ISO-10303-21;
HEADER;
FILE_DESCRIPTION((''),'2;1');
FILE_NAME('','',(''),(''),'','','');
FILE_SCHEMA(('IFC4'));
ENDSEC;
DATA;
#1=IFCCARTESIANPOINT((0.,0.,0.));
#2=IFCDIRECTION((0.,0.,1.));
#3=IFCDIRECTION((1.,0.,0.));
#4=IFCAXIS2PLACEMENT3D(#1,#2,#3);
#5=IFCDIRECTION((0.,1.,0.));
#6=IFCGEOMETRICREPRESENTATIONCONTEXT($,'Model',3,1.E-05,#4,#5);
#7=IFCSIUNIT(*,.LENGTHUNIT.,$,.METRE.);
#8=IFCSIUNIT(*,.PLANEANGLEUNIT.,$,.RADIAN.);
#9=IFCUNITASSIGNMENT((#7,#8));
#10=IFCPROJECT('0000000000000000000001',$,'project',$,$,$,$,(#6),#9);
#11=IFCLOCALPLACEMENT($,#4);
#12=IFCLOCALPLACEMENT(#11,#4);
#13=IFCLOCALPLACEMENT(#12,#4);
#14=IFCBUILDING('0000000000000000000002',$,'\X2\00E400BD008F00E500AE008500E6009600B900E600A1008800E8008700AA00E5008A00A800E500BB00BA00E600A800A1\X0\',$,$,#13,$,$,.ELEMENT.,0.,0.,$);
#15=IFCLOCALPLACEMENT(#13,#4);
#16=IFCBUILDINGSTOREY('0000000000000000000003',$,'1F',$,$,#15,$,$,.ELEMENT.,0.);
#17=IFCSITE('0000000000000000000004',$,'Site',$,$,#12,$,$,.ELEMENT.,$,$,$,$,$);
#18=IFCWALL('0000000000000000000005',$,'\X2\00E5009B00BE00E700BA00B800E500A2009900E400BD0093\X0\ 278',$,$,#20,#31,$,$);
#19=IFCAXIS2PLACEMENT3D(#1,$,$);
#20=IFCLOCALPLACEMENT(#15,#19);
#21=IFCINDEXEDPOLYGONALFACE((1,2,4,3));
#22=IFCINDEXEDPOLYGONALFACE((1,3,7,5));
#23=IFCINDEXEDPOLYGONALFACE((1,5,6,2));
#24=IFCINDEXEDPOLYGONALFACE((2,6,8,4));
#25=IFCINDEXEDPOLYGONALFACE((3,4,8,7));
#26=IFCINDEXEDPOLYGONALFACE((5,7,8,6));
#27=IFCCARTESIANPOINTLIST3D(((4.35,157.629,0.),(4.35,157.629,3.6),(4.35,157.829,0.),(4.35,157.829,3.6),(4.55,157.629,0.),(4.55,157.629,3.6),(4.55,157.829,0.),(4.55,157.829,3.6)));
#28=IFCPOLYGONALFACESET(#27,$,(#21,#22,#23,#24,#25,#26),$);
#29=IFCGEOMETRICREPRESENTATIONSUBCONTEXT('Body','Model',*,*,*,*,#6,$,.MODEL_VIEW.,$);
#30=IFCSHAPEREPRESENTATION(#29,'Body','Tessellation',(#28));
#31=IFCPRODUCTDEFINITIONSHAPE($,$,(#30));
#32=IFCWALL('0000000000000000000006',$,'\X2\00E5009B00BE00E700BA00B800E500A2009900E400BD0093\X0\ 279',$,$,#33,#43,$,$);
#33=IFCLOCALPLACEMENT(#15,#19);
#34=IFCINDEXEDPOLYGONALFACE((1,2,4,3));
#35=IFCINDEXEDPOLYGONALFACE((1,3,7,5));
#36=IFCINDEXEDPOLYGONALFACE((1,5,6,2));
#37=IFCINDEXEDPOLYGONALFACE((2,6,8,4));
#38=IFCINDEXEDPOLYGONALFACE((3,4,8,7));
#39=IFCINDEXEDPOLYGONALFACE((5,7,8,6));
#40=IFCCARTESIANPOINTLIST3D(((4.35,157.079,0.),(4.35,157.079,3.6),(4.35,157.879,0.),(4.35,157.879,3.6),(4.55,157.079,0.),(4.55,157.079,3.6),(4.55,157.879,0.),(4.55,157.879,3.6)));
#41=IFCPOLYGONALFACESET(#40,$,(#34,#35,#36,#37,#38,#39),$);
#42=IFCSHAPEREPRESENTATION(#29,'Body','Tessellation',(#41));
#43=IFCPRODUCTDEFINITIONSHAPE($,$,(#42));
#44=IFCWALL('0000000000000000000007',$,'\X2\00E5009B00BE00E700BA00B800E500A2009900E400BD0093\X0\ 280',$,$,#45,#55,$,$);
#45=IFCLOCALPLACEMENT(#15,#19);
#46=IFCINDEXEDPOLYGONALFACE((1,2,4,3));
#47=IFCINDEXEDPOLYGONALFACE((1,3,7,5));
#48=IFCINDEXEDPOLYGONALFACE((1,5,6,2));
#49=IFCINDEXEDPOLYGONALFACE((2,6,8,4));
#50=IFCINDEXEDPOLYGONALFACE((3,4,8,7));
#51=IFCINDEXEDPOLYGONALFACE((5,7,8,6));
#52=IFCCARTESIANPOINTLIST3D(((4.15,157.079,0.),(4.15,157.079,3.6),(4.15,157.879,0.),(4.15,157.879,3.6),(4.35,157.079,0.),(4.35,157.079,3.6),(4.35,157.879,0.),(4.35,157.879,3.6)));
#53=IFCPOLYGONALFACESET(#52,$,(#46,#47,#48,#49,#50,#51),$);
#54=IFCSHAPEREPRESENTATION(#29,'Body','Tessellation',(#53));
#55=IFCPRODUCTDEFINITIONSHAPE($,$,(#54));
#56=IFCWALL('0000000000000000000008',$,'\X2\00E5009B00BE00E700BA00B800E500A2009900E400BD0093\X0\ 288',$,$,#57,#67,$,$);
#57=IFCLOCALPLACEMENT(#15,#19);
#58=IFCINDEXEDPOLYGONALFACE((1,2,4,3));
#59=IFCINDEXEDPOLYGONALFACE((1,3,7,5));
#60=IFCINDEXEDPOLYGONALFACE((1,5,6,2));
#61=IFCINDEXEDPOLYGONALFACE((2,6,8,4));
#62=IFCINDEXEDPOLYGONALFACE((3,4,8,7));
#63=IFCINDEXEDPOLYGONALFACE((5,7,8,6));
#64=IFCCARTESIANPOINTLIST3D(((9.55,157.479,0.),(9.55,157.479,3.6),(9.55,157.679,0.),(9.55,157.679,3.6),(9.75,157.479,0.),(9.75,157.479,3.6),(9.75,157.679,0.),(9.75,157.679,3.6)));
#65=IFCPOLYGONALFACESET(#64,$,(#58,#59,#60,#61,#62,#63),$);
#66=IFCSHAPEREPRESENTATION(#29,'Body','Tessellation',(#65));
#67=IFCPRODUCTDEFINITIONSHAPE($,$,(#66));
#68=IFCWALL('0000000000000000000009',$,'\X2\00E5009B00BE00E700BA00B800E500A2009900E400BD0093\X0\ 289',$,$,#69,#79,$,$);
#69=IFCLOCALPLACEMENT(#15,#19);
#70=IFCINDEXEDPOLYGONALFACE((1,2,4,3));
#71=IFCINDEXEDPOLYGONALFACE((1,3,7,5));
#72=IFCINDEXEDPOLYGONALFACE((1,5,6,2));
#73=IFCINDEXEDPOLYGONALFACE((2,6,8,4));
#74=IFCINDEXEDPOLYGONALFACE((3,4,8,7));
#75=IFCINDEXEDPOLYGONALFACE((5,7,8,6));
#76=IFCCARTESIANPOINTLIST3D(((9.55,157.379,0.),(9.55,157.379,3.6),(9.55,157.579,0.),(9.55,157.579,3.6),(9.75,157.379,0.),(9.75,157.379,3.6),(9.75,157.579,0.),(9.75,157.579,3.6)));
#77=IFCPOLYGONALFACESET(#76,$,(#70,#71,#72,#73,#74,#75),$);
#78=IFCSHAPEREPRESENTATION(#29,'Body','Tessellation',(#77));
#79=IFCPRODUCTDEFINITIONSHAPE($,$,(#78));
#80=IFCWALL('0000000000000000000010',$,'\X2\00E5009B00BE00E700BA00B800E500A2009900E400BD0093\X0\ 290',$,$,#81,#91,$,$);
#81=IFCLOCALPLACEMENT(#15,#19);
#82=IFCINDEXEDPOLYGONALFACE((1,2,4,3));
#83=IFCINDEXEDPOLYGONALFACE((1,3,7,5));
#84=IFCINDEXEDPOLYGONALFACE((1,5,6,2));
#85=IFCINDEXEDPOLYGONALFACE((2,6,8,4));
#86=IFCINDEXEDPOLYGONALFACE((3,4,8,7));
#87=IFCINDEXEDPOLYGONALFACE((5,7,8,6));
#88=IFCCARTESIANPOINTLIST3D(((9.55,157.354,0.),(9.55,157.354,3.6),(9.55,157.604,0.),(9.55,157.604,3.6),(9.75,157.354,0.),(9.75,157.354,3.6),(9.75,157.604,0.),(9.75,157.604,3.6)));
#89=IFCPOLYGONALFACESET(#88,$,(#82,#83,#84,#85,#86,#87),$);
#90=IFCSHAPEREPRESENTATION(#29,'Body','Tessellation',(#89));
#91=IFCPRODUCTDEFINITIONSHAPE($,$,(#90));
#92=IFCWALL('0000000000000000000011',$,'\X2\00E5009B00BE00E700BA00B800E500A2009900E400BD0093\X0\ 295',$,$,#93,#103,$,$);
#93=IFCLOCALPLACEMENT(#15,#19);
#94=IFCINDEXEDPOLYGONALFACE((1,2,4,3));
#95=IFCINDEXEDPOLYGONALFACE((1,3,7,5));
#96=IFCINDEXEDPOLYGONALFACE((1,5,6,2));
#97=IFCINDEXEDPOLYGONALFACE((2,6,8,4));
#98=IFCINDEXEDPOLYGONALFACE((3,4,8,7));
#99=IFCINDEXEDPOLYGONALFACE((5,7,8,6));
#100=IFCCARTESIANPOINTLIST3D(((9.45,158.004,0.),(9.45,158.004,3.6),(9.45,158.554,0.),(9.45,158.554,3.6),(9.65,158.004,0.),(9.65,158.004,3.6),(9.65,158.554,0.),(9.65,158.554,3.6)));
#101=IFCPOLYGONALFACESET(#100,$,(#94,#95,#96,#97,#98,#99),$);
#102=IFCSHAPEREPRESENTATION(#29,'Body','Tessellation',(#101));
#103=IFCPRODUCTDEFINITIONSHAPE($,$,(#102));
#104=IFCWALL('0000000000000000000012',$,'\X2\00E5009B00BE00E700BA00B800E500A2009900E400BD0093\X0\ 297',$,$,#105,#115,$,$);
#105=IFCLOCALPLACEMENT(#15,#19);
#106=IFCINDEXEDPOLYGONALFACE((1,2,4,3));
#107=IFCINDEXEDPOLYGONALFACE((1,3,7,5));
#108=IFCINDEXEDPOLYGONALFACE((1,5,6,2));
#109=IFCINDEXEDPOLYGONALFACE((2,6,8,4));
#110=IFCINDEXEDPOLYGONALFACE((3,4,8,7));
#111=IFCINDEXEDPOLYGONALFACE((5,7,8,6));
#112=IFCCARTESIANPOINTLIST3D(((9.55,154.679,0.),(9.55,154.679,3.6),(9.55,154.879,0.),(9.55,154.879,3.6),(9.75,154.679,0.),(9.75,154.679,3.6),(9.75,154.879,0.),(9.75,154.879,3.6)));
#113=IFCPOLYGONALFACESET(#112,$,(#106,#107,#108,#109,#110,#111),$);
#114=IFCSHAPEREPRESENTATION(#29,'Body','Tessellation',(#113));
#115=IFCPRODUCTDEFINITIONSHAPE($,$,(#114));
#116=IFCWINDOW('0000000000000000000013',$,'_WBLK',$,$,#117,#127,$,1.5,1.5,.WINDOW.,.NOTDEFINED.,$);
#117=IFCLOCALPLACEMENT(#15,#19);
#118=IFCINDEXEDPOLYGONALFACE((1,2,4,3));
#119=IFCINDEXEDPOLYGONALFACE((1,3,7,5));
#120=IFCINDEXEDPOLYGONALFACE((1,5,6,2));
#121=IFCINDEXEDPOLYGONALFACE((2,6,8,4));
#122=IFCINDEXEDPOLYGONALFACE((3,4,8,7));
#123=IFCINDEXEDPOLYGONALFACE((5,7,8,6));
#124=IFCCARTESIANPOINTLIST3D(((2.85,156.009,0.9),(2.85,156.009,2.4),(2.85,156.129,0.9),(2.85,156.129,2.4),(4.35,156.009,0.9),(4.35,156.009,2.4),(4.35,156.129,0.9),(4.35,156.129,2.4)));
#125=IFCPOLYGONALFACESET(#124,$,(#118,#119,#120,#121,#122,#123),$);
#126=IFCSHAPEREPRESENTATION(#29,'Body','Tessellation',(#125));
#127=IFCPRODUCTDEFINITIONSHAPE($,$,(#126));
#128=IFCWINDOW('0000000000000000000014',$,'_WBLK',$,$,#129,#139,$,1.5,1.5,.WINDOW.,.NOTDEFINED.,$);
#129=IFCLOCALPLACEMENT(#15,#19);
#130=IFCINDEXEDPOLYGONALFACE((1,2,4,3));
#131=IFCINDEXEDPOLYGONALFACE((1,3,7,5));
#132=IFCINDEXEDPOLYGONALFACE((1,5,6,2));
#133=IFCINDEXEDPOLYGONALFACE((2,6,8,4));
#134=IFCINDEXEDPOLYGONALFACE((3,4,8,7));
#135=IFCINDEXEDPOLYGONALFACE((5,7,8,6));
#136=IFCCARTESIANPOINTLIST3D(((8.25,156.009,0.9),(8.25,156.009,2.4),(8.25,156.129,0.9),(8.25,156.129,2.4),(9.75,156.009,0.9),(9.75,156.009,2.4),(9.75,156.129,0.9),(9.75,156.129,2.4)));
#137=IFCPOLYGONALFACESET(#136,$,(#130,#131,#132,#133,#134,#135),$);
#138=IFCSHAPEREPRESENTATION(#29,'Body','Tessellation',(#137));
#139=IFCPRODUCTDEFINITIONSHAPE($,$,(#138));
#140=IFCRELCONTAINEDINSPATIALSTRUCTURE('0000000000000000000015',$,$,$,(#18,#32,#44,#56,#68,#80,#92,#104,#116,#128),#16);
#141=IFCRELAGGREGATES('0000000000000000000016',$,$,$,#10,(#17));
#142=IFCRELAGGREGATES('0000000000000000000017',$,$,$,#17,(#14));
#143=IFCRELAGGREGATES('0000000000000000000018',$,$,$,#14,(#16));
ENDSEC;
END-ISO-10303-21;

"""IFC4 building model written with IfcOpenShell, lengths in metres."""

from ifc_helpers import new_model, si_unit, direction, frame, frame_2d, origin_with_axes, place, context, subcontext, project, spatial, rectangle, extrude, element, save


model = new_model("IFC4")

# Units and contexts
model_context = context("Model", 3, precision=1e-05, world=origin_with_axes(), true_north=direction((0.0, 1.0, 0.0)))
body_context = subcontext(model_context, "Body", "Model", "MODEL_VIEW")
ifc_project = project(units=[si_unit("LENGTHUNIT", "METRE"), si_unit("PLANEANGLEUNIT", "RADIAN")], contexts=[model_context])

# Site, building, storey
placement = place(None, origin_with_axes())
site_placement = place(placement, origin_with_axes())
site = spatial("IfcSite", under=ifc_project, at=site_placement, Name="Site", CompositionType="ELEMENT")
building_placement = place(site_placement, origin_with_axes())
building = spatial("IfcBuilding", under=site, at=building_placement, Name="ä½\u008få®\u0085æ\u0096¹æ¡\u0088è\u0087ªå\u008a¨å»ºæ¨¡", CompositionType="ELEMENT", ElevationOfRefHeight=0.0, ElevationOfTerrain=0.0)
storey_placement = place(building_placement, origin_with_axes())
storey = spatial("IfcBuildingStorey", under=building, at=storey_placement, Name="1F", CompositionType="ELEMENT", Elevation=0.0)

# Walls
for number, where, z_axis, x_axis, name in (
    (1, (4.45, 157.729, 0.0), (0.0, 0.0, 1.0), (-1.0, 0.0, 0.0), "å\u009b¾çº¸å¢\u0099ä½\u0093 278"),
):
    element("IfcWall", number, at=place(storey_placement, frame(where, z_axis=z_axis, x_axis=x_axis)), inside=storey, Name=name, context=body_context, shape_type="SweptSolid", body=[
        extrude(rectangle(XDim=0.2, YDim=0.2, at=frame_2d((0.0, 0.0), x_axis=(1.0, 0.0, 0.0))), frame((0.0, 0.0, 0.0), z_axis=(0.0, 0.0, 1.0)), (0.0, 0.0, 1.0), 3.6),
    ])
for number, where, z_axis, x_axis, name in (
    (2, (4.45, 157.479, 0.0), (0.0, 0.0, 1.0), (0.0, 1.0, 0.0), "å\u009b¾çº¸å¢\u0099ä½\u0093 279"),
    (3, (4.25, 157.479, 0.0), (0.0, 0.0, 1.0), (0.0, 1.0, 0.0), "å\u009b¾çº¸å¢\u0099ä½\u0093 280"),
):
    element("IfcWall", number, at=place(storey_placement, frame(where, z_axis=z_axis, x_axis=x_axis)), inside=storey, Name=name, context=body_context, shape_type="SweptSolid", body=[
        extrude(rectangle(XDim=0.8, YDim=0.2, at=frame_2d((0.0, 0.0), x_axis=(1.0, 0.0, 0.0))), frame((0.0, 0.0, 0.0), z_axis=(0.0, 0.0, 1.0)), (0.0, 0.0, 1.0), 3.6),
    ])
for number, where, z_axis, x_axis, name in (
    (4, (9.65, 157.579, 0.0), (0.0, 0.0, 1.0), (1.0, 0.0, 0.0), "å\u009b¾çº¸å¢\u0099ä½\u0093 288"),
    (5, (9.65, 157.479, 0.0), (0.0, 0.0, 1.0), (1.0, 0.0, 0.0), "å\u009b¾çº¸å¢\u0099ä½\u0093 289"),
):
    element("IfcWall", number, at=place(storey_placement, frame(where, z_axis=z_axis, x_axis=x_axis)), inside=storey, Name=name, context=body_context, shape_type="SweptSolid", body=[
        extrude(rectangle(XDim=0.2, YDim=0.2, at=frame_2d((0.0, 0.0), x_axis=(1.0, 0.0, 0.0))), frame((0.0, 0.0, 0.0), z_axis=(0.0, 0.0, 1.0)), (0.0, 0.0, 1.0), 3.6),
    ])
wall_1_placement = place(storey_placement, frame((9.65, 157.479, 0.0), z_axis=(0.0, 0.0, 1.0), x_axis=(0.0, 1.0, 0.0)))
element("IfcWall", 6, at=wall_1_placement, inside=storey, Name="å\u009b¾çº¸å¢\u0099ä½\u0093 290", context=body_context, shape_type="SweptSolid", body=[
    extrude(rectangle(XDim=0.25, YDim=0.2, at=frame_2d((0.0, 0.0), x_axis=(1.0, 0.0, 0.0))), frame((0.0, 0.0, 0.0), z_axis=(0.0, 0.0, 1.0)), (0.0, 0.0, 1.0), 3.6),
])
wall_2_placement = place(storey_placement, frame((9.55, 158.279, 0.0), z_axis=(0.0, 0.0, 1.0), x_axis=(0.0, -1.0, 0.0)))
element("IfcWall", 7, at=wall_2_placement, inside=storey, Name="å\u009b¾çº¸å¢\u0099ä½\u0093 295", context=body_context, shape_type="SweptSolid", body=[
    extrude(rectangle(XDim=0.55, YDim=0.2, at=frame_2d((0.0, 0.0), x_axis=(1.0, 0.0, 0.0))), frame((0.0, 0.0, 0.0), z_axis=(0.0, 0.0, 1.0)), (0.0, 0.0, 1.0), 3.6),
])
wall_3_placement = place(storey_placement, frame((9.65, 154.779, 0.0), z_axis=(0.0, 0.0, 1.0), x_axis=(1.0, 0.0, 0.0)))
element("IfcWall", 8, at=wall_3_placement, inside=storey, Name="å\u009b¾çº¸å¢\u0099ä½\u0093 297", context=body_context, shape_type="SweptSolid", body=[
    extrude(rectangle(XDim=0.2, YDim=0.2, at=frame_2d((0.0, 0.0), x_axis=(1.0, 0.0, 0.0))), frame((0.0, 0.0, 0.0), z_axis=(0.0, 0.0, 1.0)), (0.0, 0.0, 1.0), 3.6),
])

# Windows
for number, where, z_axis, x_axis, name in (
    (9, (3.6, 156.069, 0.9), (0.0, 0.0, 1.0), (1.0, 0.0, 0.0), "_WBLK"),
    (10, (9.0, 156.069, 0.9), (0.0, 0.0, 1.0), (1.0, 0.0, 0.0), "_WBLK"),
):
    element("IfcWindow", number, at=place(storey_placement, frame(where, z_axis=z_axis, x_axis=x_axis)), inside=storey, Name=name, OverallHeight=1.5, OverallWidth=1.5, PartitioningType="NOTDEFINED", PredefinedType="WINDOW", context=body_context, shape_type="SweptSolid", body=[
        extrude(rectangle(XDim=1.5, YDim=0.12, at=frame_2d((0.0, 0.0), x_axis=(1.0, 0.0, 0.0))), frame((0.0, 0.0, 0.0), z_axis=(0.0, 0.0, 1.0)), (0.0, 0.0, 1.0), 1.5),
    ])

save(model, "model.ifc")
